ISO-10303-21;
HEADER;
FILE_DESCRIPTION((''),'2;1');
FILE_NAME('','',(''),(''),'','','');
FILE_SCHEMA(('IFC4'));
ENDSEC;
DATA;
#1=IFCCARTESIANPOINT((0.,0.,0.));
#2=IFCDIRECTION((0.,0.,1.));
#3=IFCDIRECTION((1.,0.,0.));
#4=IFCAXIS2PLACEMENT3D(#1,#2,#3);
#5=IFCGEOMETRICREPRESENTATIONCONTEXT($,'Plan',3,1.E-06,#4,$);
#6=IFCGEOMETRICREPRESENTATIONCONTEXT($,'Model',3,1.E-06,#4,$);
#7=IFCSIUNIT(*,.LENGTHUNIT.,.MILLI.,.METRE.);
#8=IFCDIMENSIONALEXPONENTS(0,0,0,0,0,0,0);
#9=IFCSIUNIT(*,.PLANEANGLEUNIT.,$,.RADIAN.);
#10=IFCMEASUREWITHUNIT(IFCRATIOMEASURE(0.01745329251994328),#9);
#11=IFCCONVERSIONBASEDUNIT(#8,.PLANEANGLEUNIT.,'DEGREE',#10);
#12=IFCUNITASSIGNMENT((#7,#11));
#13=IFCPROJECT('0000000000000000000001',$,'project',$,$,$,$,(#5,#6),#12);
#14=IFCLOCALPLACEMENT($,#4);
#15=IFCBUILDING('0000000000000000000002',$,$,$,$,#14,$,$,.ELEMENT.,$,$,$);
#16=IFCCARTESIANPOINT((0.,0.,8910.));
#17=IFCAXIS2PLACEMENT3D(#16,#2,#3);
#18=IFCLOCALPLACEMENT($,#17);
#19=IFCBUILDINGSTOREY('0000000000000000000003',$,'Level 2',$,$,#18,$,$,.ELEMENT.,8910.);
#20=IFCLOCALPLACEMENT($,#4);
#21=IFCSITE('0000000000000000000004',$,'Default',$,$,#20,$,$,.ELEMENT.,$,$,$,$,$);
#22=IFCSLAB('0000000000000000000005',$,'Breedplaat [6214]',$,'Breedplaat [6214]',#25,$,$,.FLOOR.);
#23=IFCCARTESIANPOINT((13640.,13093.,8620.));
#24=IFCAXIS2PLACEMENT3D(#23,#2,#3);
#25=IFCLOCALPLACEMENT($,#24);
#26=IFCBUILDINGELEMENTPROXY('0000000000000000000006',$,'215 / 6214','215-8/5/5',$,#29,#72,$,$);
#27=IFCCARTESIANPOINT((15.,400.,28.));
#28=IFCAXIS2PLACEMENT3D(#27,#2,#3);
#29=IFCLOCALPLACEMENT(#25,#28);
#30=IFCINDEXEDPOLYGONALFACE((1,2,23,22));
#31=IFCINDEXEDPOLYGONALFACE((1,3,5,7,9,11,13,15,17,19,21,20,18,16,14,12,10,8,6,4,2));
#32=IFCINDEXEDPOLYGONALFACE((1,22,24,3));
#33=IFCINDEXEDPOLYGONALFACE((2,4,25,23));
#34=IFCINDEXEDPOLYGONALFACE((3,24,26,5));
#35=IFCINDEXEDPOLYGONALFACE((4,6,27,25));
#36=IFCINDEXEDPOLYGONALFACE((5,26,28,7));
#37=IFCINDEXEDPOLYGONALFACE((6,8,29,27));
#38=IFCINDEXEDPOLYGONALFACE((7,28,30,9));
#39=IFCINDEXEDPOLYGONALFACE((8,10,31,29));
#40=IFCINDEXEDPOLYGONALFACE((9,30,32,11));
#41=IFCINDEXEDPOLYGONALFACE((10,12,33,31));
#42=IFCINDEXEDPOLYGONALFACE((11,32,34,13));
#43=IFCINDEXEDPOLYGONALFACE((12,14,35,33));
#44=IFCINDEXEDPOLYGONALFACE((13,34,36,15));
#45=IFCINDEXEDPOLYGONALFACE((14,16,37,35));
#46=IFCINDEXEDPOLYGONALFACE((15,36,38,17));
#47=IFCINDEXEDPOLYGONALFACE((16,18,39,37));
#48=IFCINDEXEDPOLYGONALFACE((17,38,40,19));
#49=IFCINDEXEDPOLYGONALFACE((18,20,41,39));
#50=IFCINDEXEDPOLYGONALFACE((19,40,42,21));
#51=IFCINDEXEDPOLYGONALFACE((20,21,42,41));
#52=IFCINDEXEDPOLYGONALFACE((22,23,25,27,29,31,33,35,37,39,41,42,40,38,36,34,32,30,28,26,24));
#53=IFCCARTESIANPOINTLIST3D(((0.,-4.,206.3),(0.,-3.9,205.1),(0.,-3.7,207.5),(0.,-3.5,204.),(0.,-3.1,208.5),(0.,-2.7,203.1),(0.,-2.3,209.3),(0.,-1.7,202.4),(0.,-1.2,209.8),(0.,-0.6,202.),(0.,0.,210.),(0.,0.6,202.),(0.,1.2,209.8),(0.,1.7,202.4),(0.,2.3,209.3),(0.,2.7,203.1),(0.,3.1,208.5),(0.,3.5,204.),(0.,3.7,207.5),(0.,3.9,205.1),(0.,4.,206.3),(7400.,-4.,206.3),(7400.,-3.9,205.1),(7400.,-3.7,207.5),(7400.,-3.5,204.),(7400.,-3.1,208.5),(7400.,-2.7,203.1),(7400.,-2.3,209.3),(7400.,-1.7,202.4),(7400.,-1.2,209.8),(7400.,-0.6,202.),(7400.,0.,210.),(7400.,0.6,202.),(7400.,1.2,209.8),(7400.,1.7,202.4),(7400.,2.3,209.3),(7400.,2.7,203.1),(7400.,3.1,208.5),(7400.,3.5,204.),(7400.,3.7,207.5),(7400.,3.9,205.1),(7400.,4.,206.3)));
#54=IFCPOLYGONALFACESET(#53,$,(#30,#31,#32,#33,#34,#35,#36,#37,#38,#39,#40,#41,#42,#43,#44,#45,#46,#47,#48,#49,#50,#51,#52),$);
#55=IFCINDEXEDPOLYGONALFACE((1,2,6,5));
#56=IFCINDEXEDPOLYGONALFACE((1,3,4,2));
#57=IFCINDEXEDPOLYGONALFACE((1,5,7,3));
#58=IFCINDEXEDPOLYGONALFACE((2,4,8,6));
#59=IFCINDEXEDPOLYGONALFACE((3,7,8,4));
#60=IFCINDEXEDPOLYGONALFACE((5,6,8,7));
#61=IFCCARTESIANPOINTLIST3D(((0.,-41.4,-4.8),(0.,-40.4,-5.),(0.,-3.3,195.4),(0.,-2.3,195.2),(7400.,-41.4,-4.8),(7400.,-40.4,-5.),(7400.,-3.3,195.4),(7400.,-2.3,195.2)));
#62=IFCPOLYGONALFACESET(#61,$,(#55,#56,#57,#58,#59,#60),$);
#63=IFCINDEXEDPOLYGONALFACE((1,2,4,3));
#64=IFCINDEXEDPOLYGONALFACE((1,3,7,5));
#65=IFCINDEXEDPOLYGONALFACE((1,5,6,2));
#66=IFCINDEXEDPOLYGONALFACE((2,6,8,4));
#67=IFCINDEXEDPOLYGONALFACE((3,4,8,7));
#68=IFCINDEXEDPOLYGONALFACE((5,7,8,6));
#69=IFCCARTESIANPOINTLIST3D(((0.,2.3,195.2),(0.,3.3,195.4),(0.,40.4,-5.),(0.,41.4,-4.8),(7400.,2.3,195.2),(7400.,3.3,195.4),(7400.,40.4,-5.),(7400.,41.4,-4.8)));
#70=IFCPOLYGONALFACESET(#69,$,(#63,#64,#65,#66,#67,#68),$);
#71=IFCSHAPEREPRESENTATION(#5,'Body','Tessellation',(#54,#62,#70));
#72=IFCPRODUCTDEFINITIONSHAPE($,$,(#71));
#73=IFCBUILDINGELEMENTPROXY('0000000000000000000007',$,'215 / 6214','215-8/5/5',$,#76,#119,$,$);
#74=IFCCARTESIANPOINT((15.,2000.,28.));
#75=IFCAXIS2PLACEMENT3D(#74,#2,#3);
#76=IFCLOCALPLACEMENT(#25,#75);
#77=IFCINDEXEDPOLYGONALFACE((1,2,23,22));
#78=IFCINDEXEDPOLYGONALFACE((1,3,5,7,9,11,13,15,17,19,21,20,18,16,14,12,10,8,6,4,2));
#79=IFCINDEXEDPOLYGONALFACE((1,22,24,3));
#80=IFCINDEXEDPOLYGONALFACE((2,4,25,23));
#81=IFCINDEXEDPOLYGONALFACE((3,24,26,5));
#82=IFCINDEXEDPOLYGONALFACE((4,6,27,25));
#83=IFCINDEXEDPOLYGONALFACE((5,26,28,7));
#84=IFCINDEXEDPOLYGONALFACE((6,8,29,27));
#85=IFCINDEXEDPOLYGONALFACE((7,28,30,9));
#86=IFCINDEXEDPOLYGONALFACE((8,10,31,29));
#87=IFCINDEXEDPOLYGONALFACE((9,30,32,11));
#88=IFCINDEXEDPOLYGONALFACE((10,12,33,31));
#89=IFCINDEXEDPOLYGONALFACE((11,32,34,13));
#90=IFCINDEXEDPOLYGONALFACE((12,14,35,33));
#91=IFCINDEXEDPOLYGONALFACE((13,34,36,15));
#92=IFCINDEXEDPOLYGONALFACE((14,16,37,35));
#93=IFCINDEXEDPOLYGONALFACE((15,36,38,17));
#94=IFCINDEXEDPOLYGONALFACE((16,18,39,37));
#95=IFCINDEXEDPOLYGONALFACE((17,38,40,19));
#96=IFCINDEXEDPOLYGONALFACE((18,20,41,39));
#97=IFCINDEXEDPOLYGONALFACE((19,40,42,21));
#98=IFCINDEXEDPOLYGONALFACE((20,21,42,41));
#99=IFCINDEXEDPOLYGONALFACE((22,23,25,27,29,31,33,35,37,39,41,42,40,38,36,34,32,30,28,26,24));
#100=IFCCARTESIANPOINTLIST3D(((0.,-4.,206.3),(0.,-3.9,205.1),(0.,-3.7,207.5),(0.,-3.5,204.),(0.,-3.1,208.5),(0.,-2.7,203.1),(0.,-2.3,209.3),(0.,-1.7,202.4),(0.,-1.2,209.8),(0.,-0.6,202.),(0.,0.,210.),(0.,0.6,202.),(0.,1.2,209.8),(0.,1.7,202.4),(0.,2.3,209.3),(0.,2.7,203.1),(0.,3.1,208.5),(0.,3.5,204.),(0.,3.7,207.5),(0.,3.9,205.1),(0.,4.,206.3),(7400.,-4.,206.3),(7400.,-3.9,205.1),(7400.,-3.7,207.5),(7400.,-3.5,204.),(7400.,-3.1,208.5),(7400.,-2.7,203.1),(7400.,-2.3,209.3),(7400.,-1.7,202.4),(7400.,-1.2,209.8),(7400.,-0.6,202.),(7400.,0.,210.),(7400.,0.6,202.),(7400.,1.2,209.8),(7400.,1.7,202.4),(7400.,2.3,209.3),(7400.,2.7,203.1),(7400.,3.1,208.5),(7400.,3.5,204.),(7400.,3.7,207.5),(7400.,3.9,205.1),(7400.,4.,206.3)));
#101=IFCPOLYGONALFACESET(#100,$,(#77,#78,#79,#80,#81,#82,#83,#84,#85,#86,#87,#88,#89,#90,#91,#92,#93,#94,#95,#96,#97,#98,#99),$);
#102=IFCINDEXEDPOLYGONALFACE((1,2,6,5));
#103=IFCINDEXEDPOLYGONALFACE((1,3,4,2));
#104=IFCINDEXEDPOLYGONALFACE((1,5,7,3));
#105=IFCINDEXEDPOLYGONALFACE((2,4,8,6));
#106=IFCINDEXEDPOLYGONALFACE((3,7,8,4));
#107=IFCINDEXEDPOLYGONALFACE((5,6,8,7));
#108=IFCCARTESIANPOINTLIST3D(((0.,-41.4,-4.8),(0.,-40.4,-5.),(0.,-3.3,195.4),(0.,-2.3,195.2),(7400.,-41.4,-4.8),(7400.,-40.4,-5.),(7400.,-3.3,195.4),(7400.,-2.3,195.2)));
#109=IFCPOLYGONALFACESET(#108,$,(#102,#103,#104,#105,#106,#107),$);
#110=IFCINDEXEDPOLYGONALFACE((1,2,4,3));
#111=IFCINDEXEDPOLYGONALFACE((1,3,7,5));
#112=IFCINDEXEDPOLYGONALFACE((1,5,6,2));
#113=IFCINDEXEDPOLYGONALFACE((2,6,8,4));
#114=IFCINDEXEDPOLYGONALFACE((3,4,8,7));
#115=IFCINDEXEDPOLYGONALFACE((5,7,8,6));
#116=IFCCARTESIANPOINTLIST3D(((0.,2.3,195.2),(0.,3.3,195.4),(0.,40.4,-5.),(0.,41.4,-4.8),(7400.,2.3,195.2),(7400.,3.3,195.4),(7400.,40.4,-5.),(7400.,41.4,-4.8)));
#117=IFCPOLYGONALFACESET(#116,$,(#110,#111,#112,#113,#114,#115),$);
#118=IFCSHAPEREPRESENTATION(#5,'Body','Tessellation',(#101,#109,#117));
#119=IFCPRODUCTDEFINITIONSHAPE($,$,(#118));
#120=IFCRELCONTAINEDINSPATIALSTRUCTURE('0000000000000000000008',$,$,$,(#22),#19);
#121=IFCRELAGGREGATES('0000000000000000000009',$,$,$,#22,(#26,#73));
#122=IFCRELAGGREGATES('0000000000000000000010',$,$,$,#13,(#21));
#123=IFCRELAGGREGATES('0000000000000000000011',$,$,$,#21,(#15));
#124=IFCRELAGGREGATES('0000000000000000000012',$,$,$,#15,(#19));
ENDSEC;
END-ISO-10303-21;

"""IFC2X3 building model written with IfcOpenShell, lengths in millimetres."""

from ifc_helpers import new_model, entity, si_unit, converted_unit, frame, origin_with_axes, origin_2d_with_axis, place, context, project, spatial, rectangle, circle, extrude, element, aggregate, save


model = new_model("IFC2X3")

# Units and contexts
plan_context = context("Plan", 3, precision=1e-06, world=origin_with_axes())
model_context = context("Model", 3, precision=1e-06, world=origin_with_axes())
ifc_project = project(units=[si_unit("LENGTHUNIT", "METRE", prefix="MILLI"), converted_unit("PLANEANGLEUNIT", "DEGREE", entity("IfcRatioMeasure", 0.01745329251994328), si_unit("PLANEANGLEUNIT", "RADIAN"), dimensions=[0, 0, 0, 0, 0, 0, 0])], contexts=[plan_context, model_context])

# Site, building, storey
site_placement = place(None, origin_with_axes())
site = spatial("IfcSite", under=ifc_project, at=site_placement, Name="Default", CompositionType="ELEMENT")
building_placement = place(None, origin_with_axes())
building = spatial("IfcBuilding", under=site, at=building_placement, CompositionType="ELEMENT")
storey_placement = place(None, frame((0.0, 0.0, 8910.0), z_axis=(0.0, 0.0, 1.0), x_axis=(1.0, 0.0, 0.0)))
storey = spatial("IfcBuildingStorey", under=building, at=storey_placement, Name="Level 2", CompositionType="ELEMENT", Elevation=8910.0)

# Slab, building element proxies
slab_1_placement = place(None, frame((13640.0, 13093.0, 8620.0), z_axis=(0.0, 0.0, 1.0), x_axis=(1.0, 0.0, 0.0)))
slab_1 = element("IfcSlab", 1, at=slab_1_placement, inside=storey, Name="Breedplaat [6214]", ObjectType="Breedplaat [6214]", PredefinedType="FLOOR")
proxy_1_placement = place(slab_1_placement, frame((15.0, 400.0, 28.0), z_axis=(0.0, 0.0, 1.0), x_axis=(1.0, 0.0, 0.0)))
proxy_1 = element("IfcBuildingElementProxy", 2, at=proxy_1_placement, Name="215 / 6214", Description="215-8/5/5", context=plan_context, shape_type="SweptSolid", body=[
    extrude(circle(Radius=4.0, at=origin_2d_with_axis()), frame((0.0, 0.0, 206.0), z_axis=(1.0, 0.0, 0.0), x_axis=(0.0, 0.0, 1.0)), (0.0, 0.0, 1.0), 7400.0),
    extrude(rectangle(XDim=203.8, YDim=1.0, at=origin_2d_with_axis()), frame((0.0, -21.9, 95.2), z_axis=(1.0, 0.0, 0.0), x_axis=(0.0, 0.187112, 0.982339)), (0.0, 0.0, 1.0), 7400.0),
    extrude(rectangle(XDim=203.8, YDim=1.0, at=origin_2d_with_axis()), frame((0.0, 21.9, 95.2), z_axis=(1.0, 0.0, 0.0), x_axis=(0.0, -0.187112, 0.982339)), (0.0, 0.0, 1.0), 7400.0),
])
proxy_2_placement = place(slab_1_placement, frame((15.0, 2000.0, 28.0), z_axis=(0.0, 0.0, 1.0), x_axis=(1.0, 0.0, 0.0)))
proxy_2 = element("IfcBuildingElementProxy", 3, at=proxy_2_placement, Name="215 / 6214", Description="215-8/5/5", context=plan_context, shape_type="SweptSolid", body=[
    extrude(circle(Radius=4.0, at=origin_2d_with_axis()), frame((0.0, 0.0, 206.0), z_axis=(1.0, 0.0, 0.0), x_axis=(0.0, 0.0, 1.0)), (0.0, 0.0, 1.0), 7400.0),
    extrude(rectangle(XDim=203.8, YDim=1.0, at=origin_2d_with_axis()), frame((0.0, -21.9, 95.2), z_axis=(1.0, 0.0, 0.0), x_axis=(0.0, 0.187112, 0.982339)), (0.0, 0.0, 1.0), 7400.0),
    extrude(rectangle(XDim=203.8, YDim=1.0, at=origin_2d_with_axis()), frame((0.0, 21.9, 95.2), z_axis=(1.0, 0.0, 0.0), x_axis=(0.0, -0.187112, 0.982339)), (0.0, 0.0, 1.0), 7400.0),
])
aggregate(slab_1, [proxy_1, proxy_2])

save(model, "model.ifc")
